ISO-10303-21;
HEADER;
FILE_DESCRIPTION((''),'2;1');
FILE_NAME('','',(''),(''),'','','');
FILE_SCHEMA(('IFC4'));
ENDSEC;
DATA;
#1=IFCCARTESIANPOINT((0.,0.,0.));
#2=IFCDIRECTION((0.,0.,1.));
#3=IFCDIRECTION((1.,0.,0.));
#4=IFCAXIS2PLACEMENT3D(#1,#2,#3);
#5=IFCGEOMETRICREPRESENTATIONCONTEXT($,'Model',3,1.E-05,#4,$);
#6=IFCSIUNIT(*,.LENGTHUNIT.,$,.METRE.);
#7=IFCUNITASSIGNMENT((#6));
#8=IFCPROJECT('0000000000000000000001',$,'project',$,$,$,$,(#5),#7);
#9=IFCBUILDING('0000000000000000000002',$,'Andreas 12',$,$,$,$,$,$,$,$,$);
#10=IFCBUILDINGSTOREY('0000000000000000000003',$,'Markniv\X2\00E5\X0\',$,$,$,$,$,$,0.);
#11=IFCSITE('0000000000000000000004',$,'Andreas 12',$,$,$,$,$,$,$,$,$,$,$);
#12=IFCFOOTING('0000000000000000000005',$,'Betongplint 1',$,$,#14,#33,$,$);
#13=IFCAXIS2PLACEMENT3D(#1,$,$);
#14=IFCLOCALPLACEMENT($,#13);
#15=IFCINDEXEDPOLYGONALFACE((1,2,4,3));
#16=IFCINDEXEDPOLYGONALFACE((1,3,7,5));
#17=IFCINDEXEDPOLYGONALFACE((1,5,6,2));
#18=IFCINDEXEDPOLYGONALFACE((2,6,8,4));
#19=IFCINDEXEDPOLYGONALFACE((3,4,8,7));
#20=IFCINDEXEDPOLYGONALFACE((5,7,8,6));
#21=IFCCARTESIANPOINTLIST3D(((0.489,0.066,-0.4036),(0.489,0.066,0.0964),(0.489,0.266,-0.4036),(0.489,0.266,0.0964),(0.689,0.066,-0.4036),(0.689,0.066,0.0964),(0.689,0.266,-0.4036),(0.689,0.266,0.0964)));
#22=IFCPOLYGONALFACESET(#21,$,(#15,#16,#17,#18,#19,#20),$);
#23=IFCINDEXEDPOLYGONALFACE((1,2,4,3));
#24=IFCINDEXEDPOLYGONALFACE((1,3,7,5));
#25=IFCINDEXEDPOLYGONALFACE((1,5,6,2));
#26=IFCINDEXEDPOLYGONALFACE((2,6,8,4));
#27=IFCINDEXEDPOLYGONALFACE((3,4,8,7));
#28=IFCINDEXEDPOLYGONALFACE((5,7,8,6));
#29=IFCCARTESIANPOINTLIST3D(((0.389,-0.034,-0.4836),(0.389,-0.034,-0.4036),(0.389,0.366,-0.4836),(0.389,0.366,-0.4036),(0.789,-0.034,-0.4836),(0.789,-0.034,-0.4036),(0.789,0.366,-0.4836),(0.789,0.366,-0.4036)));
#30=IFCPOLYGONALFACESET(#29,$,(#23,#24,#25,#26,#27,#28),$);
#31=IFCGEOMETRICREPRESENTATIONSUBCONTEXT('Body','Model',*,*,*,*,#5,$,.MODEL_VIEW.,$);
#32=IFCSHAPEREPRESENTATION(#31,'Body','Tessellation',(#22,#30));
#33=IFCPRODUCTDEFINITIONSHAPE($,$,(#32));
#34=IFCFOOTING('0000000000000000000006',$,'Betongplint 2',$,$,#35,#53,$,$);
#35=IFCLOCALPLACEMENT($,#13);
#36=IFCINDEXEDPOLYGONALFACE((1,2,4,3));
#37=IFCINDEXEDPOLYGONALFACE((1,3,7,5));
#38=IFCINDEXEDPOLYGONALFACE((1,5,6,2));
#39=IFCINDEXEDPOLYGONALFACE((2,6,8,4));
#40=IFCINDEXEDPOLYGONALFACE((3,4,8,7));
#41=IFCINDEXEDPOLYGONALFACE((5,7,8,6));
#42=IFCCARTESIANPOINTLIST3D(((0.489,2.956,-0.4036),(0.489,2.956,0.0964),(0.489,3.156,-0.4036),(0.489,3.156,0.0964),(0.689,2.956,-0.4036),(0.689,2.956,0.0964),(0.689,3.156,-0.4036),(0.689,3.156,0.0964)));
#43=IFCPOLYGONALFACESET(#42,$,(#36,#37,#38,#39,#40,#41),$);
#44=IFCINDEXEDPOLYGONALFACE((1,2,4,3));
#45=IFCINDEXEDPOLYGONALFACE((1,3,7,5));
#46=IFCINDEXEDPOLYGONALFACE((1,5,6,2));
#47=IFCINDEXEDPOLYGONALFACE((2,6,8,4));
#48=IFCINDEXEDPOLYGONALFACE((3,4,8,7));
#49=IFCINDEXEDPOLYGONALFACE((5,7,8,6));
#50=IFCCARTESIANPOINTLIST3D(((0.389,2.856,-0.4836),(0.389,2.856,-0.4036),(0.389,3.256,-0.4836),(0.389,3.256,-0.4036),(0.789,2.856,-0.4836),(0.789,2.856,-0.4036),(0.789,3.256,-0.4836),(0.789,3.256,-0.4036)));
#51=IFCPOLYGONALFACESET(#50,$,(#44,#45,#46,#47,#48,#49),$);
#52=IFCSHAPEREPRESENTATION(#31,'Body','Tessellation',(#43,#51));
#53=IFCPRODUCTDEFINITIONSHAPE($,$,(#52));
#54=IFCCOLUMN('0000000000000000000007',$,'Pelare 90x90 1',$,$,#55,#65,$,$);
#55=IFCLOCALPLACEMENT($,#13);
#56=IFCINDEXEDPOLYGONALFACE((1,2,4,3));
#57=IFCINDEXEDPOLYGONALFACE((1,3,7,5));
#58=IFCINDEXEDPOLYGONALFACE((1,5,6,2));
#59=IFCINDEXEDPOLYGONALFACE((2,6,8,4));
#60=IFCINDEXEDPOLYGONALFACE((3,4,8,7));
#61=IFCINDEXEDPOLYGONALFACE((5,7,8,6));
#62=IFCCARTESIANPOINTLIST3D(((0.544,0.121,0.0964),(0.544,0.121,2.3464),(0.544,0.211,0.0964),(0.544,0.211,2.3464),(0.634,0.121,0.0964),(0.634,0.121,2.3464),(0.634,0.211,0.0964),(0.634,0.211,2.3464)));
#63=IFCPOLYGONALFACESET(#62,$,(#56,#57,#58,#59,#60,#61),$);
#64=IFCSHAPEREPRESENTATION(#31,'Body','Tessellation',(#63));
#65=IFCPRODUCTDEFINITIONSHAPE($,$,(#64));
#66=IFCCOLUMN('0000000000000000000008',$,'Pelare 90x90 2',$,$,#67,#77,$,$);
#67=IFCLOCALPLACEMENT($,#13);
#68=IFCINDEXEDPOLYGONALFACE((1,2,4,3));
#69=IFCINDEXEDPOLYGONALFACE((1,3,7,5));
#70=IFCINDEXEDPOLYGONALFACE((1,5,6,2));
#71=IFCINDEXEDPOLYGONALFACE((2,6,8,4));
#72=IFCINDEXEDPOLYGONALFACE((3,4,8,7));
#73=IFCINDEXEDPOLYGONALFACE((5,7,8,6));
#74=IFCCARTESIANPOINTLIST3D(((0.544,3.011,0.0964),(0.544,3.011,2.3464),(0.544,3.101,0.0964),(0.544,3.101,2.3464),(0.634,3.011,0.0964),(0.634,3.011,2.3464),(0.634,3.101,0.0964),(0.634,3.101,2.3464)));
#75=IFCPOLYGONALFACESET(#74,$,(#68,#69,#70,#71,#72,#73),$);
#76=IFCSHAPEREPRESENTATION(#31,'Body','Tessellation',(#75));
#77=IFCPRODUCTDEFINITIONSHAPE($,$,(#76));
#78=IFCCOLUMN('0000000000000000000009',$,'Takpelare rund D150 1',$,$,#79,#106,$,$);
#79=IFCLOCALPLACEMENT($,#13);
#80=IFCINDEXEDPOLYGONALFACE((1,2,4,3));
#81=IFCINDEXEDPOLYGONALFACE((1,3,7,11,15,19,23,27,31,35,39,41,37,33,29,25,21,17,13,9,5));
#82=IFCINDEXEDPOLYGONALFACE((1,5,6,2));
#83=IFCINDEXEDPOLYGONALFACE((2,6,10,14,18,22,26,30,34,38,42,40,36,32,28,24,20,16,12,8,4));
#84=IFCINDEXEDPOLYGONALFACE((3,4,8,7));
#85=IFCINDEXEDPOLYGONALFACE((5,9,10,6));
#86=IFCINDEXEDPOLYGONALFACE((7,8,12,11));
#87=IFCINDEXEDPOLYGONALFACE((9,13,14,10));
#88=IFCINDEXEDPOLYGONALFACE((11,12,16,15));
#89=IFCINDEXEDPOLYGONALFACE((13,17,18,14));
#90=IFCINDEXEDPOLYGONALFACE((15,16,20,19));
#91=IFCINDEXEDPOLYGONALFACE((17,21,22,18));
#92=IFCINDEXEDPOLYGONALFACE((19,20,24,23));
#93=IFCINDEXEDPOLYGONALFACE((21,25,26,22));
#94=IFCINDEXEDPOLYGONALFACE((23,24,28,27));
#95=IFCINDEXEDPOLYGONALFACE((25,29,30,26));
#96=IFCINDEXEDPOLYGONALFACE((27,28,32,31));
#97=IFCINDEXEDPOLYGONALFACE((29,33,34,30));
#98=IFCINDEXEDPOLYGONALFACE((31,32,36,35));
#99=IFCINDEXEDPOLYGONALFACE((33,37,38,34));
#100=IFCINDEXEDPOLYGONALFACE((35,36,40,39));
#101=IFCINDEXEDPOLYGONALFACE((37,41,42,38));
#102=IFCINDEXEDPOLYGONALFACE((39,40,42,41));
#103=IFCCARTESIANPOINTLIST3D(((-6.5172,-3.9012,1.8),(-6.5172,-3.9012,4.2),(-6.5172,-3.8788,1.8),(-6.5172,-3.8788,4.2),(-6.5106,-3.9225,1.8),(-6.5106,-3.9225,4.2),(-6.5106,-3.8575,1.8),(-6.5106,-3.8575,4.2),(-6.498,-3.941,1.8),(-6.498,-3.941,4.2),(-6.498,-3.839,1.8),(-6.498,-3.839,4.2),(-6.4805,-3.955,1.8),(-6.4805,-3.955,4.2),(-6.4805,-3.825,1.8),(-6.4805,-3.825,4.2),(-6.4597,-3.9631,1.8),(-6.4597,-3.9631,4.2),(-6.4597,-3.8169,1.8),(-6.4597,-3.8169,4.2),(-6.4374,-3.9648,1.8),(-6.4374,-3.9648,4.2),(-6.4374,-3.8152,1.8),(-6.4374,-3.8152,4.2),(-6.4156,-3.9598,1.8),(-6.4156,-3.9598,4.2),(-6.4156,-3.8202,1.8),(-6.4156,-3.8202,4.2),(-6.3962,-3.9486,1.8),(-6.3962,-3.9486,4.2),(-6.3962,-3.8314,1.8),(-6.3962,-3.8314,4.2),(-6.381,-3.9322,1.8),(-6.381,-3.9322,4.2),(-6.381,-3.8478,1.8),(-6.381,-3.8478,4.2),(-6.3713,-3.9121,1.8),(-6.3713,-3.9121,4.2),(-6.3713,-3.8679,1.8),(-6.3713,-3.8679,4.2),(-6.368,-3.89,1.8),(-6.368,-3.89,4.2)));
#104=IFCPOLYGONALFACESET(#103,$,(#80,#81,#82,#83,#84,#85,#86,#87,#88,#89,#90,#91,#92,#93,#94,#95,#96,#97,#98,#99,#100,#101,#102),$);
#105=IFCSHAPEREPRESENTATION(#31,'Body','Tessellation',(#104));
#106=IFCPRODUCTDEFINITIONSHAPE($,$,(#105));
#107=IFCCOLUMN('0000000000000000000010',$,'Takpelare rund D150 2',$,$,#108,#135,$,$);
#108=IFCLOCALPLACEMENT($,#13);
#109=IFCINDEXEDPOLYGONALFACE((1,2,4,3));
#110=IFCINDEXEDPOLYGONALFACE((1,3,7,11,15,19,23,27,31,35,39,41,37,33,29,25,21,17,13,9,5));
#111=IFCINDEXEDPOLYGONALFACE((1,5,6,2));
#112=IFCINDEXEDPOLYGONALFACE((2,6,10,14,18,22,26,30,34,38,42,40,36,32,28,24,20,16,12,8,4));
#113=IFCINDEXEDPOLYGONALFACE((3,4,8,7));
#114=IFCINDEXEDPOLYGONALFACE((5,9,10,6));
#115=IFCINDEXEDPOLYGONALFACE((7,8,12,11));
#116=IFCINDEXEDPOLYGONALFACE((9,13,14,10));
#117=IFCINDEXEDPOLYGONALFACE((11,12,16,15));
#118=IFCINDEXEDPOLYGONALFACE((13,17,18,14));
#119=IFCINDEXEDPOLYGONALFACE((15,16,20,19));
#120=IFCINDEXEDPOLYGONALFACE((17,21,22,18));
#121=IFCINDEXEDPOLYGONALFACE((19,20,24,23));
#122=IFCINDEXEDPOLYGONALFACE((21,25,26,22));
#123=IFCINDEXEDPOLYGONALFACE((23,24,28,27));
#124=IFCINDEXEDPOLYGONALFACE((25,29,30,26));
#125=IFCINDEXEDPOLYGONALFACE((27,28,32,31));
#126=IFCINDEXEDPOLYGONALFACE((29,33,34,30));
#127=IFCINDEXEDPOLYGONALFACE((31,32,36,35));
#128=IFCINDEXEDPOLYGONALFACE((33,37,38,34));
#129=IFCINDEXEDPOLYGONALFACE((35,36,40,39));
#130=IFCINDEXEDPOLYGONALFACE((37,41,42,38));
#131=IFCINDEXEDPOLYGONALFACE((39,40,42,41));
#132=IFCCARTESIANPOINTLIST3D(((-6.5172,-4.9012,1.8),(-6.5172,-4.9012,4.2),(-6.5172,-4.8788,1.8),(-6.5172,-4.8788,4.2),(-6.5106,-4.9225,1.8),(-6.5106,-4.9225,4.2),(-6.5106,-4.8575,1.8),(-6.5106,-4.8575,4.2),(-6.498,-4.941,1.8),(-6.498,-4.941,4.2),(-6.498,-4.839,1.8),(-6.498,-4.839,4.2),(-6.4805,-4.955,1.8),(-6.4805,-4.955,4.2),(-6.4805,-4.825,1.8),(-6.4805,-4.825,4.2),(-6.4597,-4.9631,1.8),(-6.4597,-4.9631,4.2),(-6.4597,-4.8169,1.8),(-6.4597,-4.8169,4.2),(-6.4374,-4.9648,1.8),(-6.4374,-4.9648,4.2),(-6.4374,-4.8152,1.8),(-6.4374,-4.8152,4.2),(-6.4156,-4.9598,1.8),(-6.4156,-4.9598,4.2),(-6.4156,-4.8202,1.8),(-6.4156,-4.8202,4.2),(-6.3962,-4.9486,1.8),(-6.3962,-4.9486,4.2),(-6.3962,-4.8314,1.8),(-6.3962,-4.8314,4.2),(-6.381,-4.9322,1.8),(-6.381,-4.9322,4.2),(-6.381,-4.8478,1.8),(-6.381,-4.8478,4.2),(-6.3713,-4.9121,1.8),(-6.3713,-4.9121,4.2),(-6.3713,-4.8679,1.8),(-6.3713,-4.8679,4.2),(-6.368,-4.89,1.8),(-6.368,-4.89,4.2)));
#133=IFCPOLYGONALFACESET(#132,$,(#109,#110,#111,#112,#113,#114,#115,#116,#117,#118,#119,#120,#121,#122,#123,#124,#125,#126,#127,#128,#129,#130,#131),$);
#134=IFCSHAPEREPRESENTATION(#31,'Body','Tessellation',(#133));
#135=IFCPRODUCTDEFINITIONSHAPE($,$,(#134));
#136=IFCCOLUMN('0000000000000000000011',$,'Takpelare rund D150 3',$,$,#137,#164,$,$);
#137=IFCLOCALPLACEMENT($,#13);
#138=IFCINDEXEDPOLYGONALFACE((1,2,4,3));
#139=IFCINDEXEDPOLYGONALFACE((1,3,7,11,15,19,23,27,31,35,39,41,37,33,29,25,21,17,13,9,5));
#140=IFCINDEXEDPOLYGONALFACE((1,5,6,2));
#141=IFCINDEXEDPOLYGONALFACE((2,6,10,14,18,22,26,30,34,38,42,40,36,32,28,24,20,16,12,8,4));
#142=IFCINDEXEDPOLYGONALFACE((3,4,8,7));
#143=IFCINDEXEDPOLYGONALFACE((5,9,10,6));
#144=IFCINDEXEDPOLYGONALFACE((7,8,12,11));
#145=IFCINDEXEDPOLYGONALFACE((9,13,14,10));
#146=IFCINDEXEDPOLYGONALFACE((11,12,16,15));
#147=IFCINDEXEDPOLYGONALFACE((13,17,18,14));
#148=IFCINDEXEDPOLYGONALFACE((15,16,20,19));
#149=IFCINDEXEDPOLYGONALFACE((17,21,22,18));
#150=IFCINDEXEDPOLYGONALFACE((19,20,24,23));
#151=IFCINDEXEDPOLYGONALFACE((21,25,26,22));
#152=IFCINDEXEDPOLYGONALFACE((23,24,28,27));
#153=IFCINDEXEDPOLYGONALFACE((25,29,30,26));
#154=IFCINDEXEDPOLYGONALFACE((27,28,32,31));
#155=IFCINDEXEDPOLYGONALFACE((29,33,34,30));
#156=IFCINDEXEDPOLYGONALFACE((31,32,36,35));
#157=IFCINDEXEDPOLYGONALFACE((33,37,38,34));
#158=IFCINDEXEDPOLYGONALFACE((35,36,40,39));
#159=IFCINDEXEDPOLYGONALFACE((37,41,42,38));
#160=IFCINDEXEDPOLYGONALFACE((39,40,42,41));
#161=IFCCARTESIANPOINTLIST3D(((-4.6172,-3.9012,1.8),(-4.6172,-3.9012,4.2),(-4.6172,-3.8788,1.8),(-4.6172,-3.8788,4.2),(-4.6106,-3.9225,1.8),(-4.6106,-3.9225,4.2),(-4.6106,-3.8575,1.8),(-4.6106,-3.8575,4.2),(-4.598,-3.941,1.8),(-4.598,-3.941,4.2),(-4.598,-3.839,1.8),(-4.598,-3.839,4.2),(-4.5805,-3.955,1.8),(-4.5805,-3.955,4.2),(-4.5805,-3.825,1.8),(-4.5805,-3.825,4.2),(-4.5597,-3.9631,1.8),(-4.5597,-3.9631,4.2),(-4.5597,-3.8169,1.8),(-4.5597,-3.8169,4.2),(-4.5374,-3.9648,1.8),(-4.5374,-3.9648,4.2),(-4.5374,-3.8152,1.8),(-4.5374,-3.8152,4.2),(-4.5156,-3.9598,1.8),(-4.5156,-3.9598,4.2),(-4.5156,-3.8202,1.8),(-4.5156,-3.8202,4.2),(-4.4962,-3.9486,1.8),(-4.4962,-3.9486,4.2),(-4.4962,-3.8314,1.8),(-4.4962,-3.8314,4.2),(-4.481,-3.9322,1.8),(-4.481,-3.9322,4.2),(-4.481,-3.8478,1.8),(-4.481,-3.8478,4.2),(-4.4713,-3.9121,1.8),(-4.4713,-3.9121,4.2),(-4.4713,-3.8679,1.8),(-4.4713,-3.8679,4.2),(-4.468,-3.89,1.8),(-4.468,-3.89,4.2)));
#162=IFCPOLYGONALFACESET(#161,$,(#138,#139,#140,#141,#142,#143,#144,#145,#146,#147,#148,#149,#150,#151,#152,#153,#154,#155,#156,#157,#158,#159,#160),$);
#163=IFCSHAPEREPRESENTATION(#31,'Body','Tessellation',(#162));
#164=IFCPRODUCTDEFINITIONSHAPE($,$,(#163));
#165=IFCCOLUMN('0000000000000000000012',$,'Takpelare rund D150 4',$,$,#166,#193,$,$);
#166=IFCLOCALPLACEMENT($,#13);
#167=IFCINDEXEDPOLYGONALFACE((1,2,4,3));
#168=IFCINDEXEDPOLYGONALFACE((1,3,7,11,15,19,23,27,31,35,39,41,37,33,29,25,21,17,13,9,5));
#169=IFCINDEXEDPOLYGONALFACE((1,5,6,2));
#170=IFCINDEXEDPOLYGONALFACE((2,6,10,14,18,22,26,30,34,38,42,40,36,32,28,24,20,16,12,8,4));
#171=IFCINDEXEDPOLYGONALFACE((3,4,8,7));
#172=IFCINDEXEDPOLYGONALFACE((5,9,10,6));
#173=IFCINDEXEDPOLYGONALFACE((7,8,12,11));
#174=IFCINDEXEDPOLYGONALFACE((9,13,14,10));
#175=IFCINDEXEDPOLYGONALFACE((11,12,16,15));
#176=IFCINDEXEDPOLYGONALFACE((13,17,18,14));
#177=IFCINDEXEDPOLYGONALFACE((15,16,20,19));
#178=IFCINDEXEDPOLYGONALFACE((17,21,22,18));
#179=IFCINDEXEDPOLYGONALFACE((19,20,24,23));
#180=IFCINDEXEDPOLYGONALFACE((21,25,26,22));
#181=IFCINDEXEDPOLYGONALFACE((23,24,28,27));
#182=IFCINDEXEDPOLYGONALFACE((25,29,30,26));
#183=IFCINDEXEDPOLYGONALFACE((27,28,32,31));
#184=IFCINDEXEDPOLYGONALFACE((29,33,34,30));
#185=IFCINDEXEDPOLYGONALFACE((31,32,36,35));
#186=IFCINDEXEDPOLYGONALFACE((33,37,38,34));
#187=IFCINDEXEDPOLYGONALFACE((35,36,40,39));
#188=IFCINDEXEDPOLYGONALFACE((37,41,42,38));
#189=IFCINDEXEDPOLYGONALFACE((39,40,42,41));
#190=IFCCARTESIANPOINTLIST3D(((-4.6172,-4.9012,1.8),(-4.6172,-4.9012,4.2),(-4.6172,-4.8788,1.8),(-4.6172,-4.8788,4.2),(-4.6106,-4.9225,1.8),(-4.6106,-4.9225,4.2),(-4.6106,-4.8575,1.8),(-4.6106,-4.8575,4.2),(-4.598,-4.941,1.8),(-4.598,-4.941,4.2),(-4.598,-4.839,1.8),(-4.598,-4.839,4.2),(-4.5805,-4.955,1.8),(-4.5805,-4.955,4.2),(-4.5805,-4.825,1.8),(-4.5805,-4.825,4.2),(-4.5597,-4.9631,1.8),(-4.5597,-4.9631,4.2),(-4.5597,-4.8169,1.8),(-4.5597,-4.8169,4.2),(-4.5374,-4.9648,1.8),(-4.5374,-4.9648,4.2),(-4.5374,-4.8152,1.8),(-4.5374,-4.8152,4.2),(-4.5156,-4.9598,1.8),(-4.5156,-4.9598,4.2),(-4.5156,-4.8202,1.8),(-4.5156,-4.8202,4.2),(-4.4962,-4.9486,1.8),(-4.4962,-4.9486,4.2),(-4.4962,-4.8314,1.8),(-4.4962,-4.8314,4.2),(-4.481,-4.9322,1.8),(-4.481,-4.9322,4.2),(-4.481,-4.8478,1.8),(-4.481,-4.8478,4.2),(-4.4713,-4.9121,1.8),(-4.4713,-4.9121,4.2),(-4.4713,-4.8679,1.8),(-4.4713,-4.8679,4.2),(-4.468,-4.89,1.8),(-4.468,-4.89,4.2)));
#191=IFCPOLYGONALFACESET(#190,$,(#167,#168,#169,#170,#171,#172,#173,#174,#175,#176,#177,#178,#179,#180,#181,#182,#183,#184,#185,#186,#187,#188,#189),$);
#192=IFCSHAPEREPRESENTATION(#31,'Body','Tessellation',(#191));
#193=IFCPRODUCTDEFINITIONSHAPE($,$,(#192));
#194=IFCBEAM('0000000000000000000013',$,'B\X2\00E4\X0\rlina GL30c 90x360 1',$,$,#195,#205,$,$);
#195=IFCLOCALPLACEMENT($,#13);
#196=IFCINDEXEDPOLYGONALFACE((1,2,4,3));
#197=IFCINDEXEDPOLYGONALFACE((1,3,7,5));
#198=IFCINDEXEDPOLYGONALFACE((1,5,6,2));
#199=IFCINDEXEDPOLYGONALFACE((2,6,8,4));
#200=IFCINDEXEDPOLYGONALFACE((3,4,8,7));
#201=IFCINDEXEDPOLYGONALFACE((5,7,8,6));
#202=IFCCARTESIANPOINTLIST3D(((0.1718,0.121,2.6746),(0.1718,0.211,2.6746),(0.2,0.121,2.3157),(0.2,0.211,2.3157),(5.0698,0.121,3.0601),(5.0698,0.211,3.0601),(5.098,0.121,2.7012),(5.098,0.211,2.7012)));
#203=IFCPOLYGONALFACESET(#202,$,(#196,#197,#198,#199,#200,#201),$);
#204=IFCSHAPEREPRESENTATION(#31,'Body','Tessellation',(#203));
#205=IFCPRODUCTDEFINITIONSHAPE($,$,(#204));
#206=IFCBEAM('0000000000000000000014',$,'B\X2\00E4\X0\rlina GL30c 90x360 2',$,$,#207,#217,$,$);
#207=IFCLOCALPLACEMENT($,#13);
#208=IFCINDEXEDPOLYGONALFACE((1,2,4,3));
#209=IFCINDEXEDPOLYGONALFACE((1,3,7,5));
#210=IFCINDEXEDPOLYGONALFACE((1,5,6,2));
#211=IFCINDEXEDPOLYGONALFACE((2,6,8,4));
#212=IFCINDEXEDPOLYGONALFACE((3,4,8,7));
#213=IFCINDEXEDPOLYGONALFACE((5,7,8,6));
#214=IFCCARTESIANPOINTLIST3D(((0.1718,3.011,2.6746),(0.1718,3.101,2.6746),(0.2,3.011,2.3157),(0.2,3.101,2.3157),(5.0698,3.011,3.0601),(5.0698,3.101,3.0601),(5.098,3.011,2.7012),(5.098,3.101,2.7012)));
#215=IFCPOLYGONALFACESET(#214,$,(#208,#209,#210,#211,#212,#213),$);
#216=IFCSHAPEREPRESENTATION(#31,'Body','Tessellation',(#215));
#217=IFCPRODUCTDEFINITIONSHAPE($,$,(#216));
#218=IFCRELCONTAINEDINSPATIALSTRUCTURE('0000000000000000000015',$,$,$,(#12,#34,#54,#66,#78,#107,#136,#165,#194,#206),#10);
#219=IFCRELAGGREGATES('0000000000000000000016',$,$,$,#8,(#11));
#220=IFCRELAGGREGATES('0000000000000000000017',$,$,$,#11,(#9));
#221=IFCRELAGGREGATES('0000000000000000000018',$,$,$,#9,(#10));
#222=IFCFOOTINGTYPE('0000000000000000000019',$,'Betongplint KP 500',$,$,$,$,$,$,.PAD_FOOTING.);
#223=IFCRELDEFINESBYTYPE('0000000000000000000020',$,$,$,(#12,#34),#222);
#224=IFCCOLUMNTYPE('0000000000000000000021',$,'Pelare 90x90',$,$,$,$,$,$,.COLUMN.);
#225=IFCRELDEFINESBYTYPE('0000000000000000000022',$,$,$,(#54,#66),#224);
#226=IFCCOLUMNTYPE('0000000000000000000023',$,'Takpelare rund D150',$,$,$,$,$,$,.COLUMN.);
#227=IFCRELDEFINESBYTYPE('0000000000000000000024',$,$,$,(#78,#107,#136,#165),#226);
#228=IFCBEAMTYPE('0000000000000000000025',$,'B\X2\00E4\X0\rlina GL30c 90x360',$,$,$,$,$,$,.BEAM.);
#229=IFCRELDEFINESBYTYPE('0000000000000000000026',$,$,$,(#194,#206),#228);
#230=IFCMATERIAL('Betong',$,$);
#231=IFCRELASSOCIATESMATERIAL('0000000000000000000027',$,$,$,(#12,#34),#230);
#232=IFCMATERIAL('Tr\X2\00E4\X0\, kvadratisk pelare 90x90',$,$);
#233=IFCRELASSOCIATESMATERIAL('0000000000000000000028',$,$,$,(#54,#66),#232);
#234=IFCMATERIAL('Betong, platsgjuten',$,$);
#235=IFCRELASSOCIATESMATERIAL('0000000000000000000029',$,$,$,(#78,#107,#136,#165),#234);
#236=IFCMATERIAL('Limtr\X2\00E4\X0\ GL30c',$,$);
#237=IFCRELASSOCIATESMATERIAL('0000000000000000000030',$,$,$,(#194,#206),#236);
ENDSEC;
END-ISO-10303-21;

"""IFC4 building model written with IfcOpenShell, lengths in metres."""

from ifc_helpers import new_model, si_unit, frame, frame_2d, origin, origin_with_axes, origin_2d, place, context, subcontext, project, spatial, rectangle, circle, extrude, material, type_object, element, save


model = new_model("IFC4")

# Units and contexts
model_context = context("Model", 3, precision=1e-05, world=origin_with_axes())
body_context = subcontext(model_context, "Body", "Model", "MODEL_VIEW")
ifc_project = project(units=[si_unit("LENGTHUNIT", "METRE")], contexts=[model_context])

# Site, building, storey
site = spatial("IfcSite", under=ifc_project, Name="Andreas 12")
building = spatial("IfcBuilding", under=site, Name="Andreas 12")
storey = spatial("IfcBuildingStorey", under=building, Name="Marknivå", Elevation=0.0)

# Footings
ifc_material_1 = material(Name="Betong")
footing_type = type_object("IfcFootingType", Name="Betongplint KP 500", PredefinedType="PAD_FOOTING")
for number, where, z_axis, x_axis, name in (
    (1, (0.589, 0.166, -0.4036), (0.0, 0.0, 1.0), (1.0, 0.0, 0.0), "Betongplint 1"),
    (2, (0.589, 3.056, -0.4036), (0.0, 0.0, 1.0), (1.0, 0.0, 0.0), "Betongplint 2"),
):
    element("IfcFooting", number, at=place(None, frame(where, z_axis=z_axis, x_axis=x_axis)), inside=storey, type_object=footing_type, material=ifc_material_1, Name=name, context=body_context, shape_type="SweptSolid", body=[
        extrude(rectangle(XDim=0.2, YDim=0.2, at=frame_2d((0.1, 0.1))), frame((-0.1, -0.1, 0.0)), (0.0, 0.0, 1.0), 0.5),
        extrude(rectangle(XDim=0.4, YDim=0.4, at=frame_2d((0.2, 0.2))), frame((-0.2, -0.2, -0.08)), (0.0, 0.0, 1.0), 0.08),
    ])

# Columns
ifc_material_2 = material(Name="Trä, kvadratisk pelare 90x90")
column_type_1 = type_object("IfcColumnType", Name="Pelare 90x90", PredefinedType="COLUMN")
for number, where, z_axis, x_axis, name in (
    (3, (0.589, 0.166, 0.0964), (0.0, 0.0, 1.0), (1.0, 0.0, 0.0), "Pelare 90x90 1"),
    (4, (0.589, 3.056, 0.0964), (0.0, 0.0, 1.0), (1.0, 0.0, 0.0), "Pelare 90x90 2"),
):
    element("IfcColumn", number, at=place(None, frame(where, z_axis=z_axis, x_axis=x_axis)), inside=storey, type_object=column_type_1, material=ifc_material_2, Name=name, context=body_context, shape_type="SweptSolid", body=[
        extrude(rectangle(XDim=0.09, YDim=0.09, at=origin_2d()), origin(), (0.0, 0.0, 1.0), 2.25),
    ])
ifc_material_3 = material(Name="Betong, platsgjuten")
column_type_2 = type_object("IfcColumnType", Name="Takpelare rund D150", PredefinedType="COLUMN")
for number, where, z_axis, x_axis, name in (
    (5, (-6.443, -3.89, 1.8), (0.0, 0.0, 1.0), (1.0, 0.0, 0.0), "Takpelare rund D150 1"),
    (6, (-6.443, -4.89, 1.8), (0.0, 0.0, 1.0), (1.0, 0.0, 0.0), "Takpelare rund D150 2"),
    (7, (-4.543, -3.89, 1.8), (0.0, 0.0, 1.0), (1.0, 0.0, 0.0), "Takpelare rund D150 3"),
    (8, (-4.543, -4.89, 1.8), (0.0, 0.0, 1.0), (1.0, 0.0, 0.0), "Takpelare rund D150 4"),
):
    element("IfcColumn", number, at=place(None, frame(where, z_axis=z_axis, x_axis=x_axis)), inside=storey, type_object=column_type_2, material=ifc_material_3, Name=name, context=body_context, shape_type="SweptSolid", body=[
        extrude(circle(Radius=0.075, at=origin_2d()), origin(), (0.0, 0.0, 1.0), 2.4),
    ])

# Beams
ifc_material_4 = material(Name="Limträ GL30c")
beam_type_1 = type_object("IfcBeamType", Name="Bärlina GL30c 90x360", PredefinedType="BEAM")
for number, where, z_axis, x_axis, name in (
    (9, (0.1859, 0.166, 2.4952), (0.996917, 0.0, 0.078459), (0.0, 1.0, 0.0), "Bärlina GL30c 90x360 1"),
    (10, (0.1859, 3.056, 2.4952), (0.996917, 0.0, 0.078459), (0.0, 1.0, 0.0), "Bärlina GL30c 90x360 2"),
):
    element("IfcBeam", number, at=place(None, frame(where, z_axis=z_axis, x_axis=x_axis)), inside=storey, type_object=beam_type_1, material=ifc_material_4, Name=name, context=body_context, shape_type="SweptSolid", body=[
        extrude(rectangle(XDim=0.09, YDim=0.36, at=origin_2d()), origin(), (0.0, 0.0, 1.0), 4.9131),
    ])

save(model, "model.ifc")
